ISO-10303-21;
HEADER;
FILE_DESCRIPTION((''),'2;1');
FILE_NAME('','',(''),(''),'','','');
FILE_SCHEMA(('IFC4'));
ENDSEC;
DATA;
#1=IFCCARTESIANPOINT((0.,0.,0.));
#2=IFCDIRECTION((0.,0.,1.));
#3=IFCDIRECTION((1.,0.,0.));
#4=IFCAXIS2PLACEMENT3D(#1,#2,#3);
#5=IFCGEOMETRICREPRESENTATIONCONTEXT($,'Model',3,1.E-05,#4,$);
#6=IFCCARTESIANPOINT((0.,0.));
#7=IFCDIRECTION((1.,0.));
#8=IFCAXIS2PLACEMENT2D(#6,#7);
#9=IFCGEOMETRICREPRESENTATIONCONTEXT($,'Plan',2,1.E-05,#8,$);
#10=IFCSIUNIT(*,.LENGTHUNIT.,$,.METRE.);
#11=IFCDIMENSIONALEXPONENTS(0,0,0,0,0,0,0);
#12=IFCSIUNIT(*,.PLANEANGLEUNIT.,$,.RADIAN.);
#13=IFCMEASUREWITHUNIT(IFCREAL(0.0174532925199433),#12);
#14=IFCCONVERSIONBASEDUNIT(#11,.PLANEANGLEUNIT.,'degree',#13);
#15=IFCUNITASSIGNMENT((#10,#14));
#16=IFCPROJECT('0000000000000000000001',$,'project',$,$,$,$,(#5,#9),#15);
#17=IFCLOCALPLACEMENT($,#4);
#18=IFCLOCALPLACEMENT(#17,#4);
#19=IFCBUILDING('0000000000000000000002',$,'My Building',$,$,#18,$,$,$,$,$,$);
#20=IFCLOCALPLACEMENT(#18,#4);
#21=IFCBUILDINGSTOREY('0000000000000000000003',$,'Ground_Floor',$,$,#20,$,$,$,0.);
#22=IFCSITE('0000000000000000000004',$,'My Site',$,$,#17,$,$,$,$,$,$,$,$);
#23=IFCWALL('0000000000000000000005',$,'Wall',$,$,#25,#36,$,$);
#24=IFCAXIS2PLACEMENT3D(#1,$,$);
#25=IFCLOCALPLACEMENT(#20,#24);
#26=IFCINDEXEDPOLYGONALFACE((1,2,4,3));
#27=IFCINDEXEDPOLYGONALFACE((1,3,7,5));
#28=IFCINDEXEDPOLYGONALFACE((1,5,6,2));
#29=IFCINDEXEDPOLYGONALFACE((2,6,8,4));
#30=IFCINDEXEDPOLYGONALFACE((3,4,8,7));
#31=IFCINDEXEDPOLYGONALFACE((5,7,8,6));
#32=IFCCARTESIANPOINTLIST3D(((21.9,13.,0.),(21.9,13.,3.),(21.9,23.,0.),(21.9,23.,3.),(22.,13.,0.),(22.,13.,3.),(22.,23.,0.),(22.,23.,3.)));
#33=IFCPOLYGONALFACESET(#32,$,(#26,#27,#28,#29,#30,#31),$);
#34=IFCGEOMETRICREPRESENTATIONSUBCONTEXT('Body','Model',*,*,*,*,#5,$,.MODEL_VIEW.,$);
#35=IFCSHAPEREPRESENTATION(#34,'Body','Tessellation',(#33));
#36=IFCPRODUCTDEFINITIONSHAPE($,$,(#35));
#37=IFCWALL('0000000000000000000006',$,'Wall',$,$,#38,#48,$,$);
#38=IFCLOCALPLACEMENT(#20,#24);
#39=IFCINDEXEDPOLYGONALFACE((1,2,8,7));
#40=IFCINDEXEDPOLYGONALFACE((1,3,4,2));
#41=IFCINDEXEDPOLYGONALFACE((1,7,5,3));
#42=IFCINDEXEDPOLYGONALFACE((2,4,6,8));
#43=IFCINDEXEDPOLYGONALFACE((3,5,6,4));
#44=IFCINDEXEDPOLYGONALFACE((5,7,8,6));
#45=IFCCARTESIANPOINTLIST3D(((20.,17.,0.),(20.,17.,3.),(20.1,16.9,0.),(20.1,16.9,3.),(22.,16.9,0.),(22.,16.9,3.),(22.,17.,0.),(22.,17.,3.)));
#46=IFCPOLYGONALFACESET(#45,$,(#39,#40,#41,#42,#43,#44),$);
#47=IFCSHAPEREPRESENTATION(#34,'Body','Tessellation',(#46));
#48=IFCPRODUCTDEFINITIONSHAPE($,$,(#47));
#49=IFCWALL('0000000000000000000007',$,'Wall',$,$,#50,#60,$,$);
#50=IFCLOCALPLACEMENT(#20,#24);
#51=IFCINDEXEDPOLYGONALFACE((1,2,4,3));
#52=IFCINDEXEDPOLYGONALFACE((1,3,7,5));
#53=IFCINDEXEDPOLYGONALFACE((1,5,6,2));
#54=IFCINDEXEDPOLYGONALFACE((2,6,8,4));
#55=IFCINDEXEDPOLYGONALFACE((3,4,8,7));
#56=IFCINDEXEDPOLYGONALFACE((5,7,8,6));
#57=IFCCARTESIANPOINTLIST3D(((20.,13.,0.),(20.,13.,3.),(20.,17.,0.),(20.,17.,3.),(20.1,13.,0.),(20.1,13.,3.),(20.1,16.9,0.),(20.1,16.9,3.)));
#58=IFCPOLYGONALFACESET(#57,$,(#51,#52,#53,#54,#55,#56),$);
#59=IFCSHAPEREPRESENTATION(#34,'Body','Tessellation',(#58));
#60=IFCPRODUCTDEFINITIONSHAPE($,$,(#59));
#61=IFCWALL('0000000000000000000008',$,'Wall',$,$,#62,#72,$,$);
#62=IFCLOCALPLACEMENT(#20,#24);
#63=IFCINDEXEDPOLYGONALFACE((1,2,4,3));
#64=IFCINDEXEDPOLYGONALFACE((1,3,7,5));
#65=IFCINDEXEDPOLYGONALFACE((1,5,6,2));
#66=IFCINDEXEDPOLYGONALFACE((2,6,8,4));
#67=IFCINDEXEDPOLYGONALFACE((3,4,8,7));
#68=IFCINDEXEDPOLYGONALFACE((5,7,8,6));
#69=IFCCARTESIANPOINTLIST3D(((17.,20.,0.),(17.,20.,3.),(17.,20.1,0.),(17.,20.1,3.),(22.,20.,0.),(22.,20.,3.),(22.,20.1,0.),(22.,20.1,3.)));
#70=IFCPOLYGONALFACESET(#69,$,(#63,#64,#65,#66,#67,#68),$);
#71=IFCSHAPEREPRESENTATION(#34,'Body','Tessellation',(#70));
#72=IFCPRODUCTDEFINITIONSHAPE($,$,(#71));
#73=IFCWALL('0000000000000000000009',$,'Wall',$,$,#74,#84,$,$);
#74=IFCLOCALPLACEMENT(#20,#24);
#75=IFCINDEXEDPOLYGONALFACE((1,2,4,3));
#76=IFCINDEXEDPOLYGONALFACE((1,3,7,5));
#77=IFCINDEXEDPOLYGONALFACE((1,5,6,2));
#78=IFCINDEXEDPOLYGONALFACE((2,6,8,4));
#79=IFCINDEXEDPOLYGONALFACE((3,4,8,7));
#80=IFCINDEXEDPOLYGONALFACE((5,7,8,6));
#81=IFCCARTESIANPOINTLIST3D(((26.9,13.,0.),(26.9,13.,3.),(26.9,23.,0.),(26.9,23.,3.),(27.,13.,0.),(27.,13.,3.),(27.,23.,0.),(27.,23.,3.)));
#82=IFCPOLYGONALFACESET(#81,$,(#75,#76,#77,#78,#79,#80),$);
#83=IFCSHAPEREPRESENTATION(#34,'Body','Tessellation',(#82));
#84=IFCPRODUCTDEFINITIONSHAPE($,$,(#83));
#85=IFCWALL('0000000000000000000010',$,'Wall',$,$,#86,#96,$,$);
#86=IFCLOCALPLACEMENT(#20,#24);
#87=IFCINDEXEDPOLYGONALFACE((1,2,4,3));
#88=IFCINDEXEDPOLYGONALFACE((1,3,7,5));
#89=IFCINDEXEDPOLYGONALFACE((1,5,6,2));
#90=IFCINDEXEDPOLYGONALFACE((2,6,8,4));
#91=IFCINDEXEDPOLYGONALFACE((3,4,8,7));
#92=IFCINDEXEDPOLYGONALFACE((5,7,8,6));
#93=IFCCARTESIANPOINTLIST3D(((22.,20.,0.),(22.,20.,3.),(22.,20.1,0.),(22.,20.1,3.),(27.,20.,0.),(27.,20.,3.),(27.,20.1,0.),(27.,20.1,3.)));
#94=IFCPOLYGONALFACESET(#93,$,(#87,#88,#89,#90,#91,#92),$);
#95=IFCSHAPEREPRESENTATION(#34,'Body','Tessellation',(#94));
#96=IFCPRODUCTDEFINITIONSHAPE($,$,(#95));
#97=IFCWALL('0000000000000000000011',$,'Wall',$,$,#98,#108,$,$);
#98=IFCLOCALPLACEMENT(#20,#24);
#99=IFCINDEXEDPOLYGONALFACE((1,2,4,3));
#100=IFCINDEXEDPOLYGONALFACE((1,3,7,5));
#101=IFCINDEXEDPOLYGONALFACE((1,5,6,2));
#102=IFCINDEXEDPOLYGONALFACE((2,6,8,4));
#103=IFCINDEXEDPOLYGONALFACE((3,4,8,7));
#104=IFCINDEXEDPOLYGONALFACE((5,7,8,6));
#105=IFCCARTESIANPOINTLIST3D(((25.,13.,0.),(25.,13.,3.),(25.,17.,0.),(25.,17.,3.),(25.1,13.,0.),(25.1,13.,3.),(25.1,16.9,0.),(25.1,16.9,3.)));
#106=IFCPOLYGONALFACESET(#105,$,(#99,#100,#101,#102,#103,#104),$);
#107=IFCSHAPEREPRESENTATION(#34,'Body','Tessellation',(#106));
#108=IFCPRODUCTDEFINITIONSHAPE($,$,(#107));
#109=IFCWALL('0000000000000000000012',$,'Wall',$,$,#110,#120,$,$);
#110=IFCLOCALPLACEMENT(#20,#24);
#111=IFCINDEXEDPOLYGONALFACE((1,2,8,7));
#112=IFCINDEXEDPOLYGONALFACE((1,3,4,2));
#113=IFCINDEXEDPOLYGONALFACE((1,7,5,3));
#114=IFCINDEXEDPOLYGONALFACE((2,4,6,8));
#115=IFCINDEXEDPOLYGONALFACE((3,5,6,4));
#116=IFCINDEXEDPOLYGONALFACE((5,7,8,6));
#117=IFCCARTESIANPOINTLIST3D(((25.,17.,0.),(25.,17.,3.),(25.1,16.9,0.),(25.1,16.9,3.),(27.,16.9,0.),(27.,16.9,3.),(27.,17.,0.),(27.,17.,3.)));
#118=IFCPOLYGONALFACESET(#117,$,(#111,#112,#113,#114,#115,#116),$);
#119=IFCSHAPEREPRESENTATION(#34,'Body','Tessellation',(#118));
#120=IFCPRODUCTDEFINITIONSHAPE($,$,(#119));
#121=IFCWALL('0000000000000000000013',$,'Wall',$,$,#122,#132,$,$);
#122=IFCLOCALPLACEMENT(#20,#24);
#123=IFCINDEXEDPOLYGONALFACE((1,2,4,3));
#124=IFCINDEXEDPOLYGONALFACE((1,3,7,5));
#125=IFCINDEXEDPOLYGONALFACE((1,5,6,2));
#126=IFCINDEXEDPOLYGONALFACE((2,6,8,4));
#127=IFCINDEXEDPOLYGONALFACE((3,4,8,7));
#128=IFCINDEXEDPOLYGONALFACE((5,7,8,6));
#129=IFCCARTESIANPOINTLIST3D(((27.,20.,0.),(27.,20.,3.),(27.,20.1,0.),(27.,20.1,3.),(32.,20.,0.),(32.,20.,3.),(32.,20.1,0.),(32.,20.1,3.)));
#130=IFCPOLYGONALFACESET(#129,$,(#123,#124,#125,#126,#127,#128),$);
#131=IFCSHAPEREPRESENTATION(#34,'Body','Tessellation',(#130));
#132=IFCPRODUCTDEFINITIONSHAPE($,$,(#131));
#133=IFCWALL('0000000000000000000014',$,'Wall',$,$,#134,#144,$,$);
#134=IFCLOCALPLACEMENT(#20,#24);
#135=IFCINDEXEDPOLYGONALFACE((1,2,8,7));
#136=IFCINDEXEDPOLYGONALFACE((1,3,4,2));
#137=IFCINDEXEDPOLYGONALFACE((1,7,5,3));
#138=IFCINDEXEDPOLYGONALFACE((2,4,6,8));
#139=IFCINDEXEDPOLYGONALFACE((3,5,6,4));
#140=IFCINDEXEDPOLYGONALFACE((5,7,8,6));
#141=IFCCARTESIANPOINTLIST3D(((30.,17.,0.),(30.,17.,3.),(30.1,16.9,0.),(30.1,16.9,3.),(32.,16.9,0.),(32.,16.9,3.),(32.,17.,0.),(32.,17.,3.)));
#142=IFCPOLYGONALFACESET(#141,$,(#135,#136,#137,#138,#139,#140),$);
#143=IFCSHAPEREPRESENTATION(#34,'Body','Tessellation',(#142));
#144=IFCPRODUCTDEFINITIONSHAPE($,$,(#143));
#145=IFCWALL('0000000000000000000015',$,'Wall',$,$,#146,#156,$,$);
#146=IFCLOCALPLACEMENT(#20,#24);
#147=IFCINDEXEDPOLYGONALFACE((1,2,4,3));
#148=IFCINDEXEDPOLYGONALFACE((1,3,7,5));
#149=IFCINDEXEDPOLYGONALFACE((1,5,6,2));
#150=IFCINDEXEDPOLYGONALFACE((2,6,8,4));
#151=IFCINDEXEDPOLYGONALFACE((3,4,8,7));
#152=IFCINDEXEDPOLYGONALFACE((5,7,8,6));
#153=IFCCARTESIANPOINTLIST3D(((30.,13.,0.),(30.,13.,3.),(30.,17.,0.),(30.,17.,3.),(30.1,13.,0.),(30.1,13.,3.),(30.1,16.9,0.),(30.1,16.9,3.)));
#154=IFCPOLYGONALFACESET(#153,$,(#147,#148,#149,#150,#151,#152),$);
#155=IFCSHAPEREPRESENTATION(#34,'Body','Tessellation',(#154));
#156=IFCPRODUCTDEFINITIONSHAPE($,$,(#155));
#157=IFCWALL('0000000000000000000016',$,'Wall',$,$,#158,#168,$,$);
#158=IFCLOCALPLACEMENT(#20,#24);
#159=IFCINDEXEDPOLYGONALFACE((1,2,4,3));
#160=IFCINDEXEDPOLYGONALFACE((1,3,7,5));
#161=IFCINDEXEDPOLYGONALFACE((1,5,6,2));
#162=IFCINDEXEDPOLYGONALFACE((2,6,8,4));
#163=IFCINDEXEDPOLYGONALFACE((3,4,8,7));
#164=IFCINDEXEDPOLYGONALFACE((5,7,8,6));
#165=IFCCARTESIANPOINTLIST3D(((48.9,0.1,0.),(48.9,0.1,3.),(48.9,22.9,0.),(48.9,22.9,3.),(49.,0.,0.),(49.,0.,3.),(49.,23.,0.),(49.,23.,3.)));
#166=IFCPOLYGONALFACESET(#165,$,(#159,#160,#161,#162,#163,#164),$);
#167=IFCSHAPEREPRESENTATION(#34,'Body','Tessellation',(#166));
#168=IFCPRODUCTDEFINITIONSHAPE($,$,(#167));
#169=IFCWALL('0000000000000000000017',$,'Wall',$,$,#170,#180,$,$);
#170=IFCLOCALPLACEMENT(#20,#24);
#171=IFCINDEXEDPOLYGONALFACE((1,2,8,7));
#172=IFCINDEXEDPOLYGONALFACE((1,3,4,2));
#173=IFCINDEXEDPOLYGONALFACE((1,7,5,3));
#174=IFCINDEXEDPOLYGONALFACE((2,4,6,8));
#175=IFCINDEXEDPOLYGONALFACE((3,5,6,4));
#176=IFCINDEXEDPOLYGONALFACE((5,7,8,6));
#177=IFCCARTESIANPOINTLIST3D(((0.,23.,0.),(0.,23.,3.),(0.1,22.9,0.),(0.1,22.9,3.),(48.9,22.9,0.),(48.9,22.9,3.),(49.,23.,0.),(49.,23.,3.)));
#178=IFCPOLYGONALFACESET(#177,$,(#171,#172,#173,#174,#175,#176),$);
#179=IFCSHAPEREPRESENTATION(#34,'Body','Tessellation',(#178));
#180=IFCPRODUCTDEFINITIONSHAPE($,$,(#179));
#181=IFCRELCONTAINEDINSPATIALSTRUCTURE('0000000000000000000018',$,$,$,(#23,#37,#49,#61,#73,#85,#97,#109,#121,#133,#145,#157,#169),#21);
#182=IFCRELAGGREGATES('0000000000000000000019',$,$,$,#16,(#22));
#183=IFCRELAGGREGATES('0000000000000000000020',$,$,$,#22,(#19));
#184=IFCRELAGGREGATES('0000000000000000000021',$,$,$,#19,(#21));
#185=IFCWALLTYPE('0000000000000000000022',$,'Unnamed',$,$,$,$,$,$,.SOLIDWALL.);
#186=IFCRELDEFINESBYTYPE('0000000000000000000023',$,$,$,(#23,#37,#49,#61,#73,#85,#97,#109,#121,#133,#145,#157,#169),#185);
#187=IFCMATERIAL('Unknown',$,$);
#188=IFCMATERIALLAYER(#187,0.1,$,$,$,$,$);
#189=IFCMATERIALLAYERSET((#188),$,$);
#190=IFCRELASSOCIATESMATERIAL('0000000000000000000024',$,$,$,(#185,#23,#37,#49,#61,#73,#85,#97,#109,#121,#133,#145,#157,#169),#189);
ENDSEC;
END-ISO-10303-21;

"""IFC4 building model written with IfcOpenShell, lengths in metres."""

from ifc_helpers import new_model, entity, si_unit, converted_unit, frame, origin_with_axes, origin_2d_with_axis, place, context, subcontext, project, spatial, line, indexed_curve, outline, extrude, material, layer, layer_set, layer_usage, type_object, element, save


model = new_model("IFC4")

# Units and contexts
model_context = context("Model", 3, precision=1e-05, world=origin_with_axes())
plan_context = context("Plan", 2, precision=1e-05, world=origin_2d_with_axis())
body_context = subcontext(model_context, "Body", "Model", "MODEL_VIEW")
ifc_project = project(units=[si_unit("LENGTHUNIT", "METRE"), converted_unit("PLANEANGLEUNIT", "degree", entity("IfcReal", 0.0174532925199433), si_unit("PLANEANGLEUNIT", "RADIAN"), dimensions=[0, 0, 0, 0, 0, 0, 0])], contexts=[model_context, plan_context])

# Site, building, storey
site_placement = place(None, origin_with_axes())
site = spatial("IfcSite", under=ifc_project, at=site_placement, Name="My Site")
building_placement = place(site_placement, origin_with_axes())
building = spatial("IfcBuilding", under=site, at=building_placement, Name="My Building")
storey_placement = place(building_placement, origin_with_axes())
storey = spatial("IfcBuildingStorey", under=building, at=storey_placement, Name="Ground_Floor", Elevation=0.0)

# Walls
ifc_material = material(Name="Unknown")
ifc_layer = layer(ifc_material, 0.1)
ifc_layer_set = layer_set([ifc_layer])
wall_type = type_object("IfcWallType", Name="Unnamed", PredefinedType="SOLIDWALL", material=ifc_layer_set)
ifc_layer_usage_1 = layer_usage(ifc_layer_set, "AXIS2", "POSITIVE", 0.0)
wall_1_placement = place(storey_placement, frame((22.0, 13.0, 0.0), z_axis=(0.0, 0.0, 1.0), x_axis=(0.0, 1.0, 0.0)))
element("IfcWall", 1, at=wall_1_placement, inside=storey, type_object=wall_type, material=ifc_layer_usage_1, Name="Wall", context=body_context, shape_type="SweptSolid", body=[
    extrude(outline(indexed_curve([(0.0, 0.0), (0.0, 0.1), (10.0, 0.1), (10.0, 0.0)], segments=[line(1, 2, 3, 4, 1)])), origin_with_axes(), (0.0, 0.0, 1.0), 3.0),
])
ifc_layer_usage_2 = layer_usage(ifc_layer_set, "AXIS2", "POSITIVE", 0.0)
wall_2_placement = place(storey_placement, frame((22.0, 17.0, 0.0), z_axis=(0.0, 0.0, 1.0), x_axis=(-1.0, 0.0, 0.0)))
element("IfcWall", 2, at=wall_2_placement, inside=storey, type_object=wall_type, material=ifc_layer_usage_2, Name="Wall", context=body_context, shape_type="SweptSolid", body=[
    extrude(outline(indexed_curve([(0.0, 0.0), (0.0, 0.1), (1.9, 0.1), (2.0, 0.0)], segments=[line(1, 2, 3, 4, 1)])), origin_with_axes(), (0.0, 0.0, 1.0), 3.0),
])
ifc_layer_usage_3 = layer_usage(ifc_layer_set, "AXIS2", "POSITIVE", 0.0)
wall_3_placement = place(storey_placement, frame((20.0, 17.0, 0.0), z_axis=(0.0, 0.0, 1.0), x_axis=(0.0, -1.0, 0.0)))
element("IfcWall", 3, at=wall_3_placement, inside=storey, type_object=wall_type, material=ifc_layer_usage_3, Name="Wall", context=body_context, shape_type="SweptSolid", body=[
    extrude(outline(indexed_curve([(0.0, 0.0), (0.1, 0.1), (4.0, 0.1), (4.0, 0.0)], segments=[line(1, 2, 3, 4, 1)])), origin_with_axes(), (0.0, 0.0, 1.0), 3.0),
])
ifc_layer_usage_4 = layer_usage(ifc_layer_set, "AXIS2", "POSITIVE", 0.0)
wall_4_placement = place(storey_placement, frame((17.0, 20.0, 0.0), z_axis=(0.0, 0.0, 1.0), x_axis=(1.0, 0.0, 0.0)))
element("IfcWall", 4, at=wall_4_placement, inside=storey, type_object=wall_type, material=ifc_layer_usage_4, Name="Wall", context=body_context, shape_type="SweptSolid", body=[
    extrude(outline(indexed_curve([(0.0, 0.0), (0.0, 0.1), (5.0, 0.1), (5.0, 0.0)], segments=[line(1, 2, 3, 4, 1)])), origin_with_axes(), (0.0, 0.0, 1.0), 3.0),
])
ifc_layer_usage_5 = layer_usage(ifc_layer_set, "AXIS2", "POSITIVE", 0.0)
wall_5_placement = place(storey_placement, frame((27.0, 13.0, 0.0), z_axis=(0.0, 0.0, 1.0), x_axis=(0.0, 1.0, 0.0)))
element("IfcWall", 5, at=wall_5_placement, inside=storey, type_object=wall_type, material=ifc_layer_usage_5, Name="Wall", context=body_context, shape_type="SweptSolid", body=[
    extrude(outline(indexed_curve([(0.0, 0.0), (0.0, 0.1), (10.0, 0.1), (10.0, 0.0)], segments=[line(1, 2, 3, 4, 1)])), origin_with_axes(), (0.0, 0.0, 1.0), 3.0),
])
ifc_layer_usage_6 = layer_usage(ifc_layer_set, "AXIS2", "POSITIVE", 0.0)
wall_6_placement = place(storey_placement, frame((22.0, 20.0, 0.0), z_axis=(0.0, 0.0, 1.0), x_axis=(1.0, 0.0, 0.0)))
element("IfcWall", 6, at=wall_6_placement, inside=storey, type_object=wall_type, material=ifc_layer_usage_6, Name="Wall", context=body_context, shape_type="SweptSolid", body=[
    extrude(outline(indexed_curve([(0.0, 0.0), (0.0, 0.1), (5.0, 0.1), (5.0, 0.0)], segments=[line(1, 2, 3, 4, 1)])), origin_with_axes(), (0.0, 0.0, 1.0), 3.0),
])
ifc_layer_usage_7 = layer_usage(ifc_layer_set, "AXIS2", "POSITIVE", 0.0)
wall_7_placement = place(storey_placement, frame((25.0, 17.0, 0.0), z_axis=(0.0, 0.0, 1.0), x_axis=(0.0, -1.0, 0.0)))
element("IfcWall", 7, at=wall_7_placement, inside=storey, type_object=wall_type, material=ifc_layer_usage_7, Name="Wall", context=body_context, shape_type="SweptSolid", body=[
    extrude(outline(indexed_curve([(0.0, 0.0), (0.1, 0.1), (4.0, 0.1), (4.0, 0.0)], segments=[line(1, 2, 3, 4, 1)])), origin_with_axes(), (0.0, 0.0, 1.0), 3.0),
])
ifc_layer_usage_8 = layer_usage(ifc_layer_set, "AXIS2", "POSITIVE", 0.0)
wall_8_placement = place(storey_placement, frame((27.0, 17.0, 0.0), z_axis=(0.0, 0.0, 1.0), x_axis=(-1.0, 0.0, 0.0)))
element("IfcWall", 8, at=wall_8_placement, inside=storey, type_object=wall_type, material=ifc_layer_usage_8, Name="Wall", context=body_context, shape_type="SweptSolid", body=[
    extrude(outline(indexed_curve([(0.0, 0.0), (0.0, 0.1), (1.9, 0.1), (2.0, 0.0)], segments=[line(1, 2, 3, 4, 1)])), origin_with_axes(), (0.0, 0.0, 1.0), 3.0),
])
ifc_layer_usage_9 = layer_usage(ifc_layer_set, "AXIS2", "POSITIVE", 0.0)
wall_9_placement = place(storey_placement, frame((27.0, 20.0, 0.0), z_axis=(0.0, 0.0, 1.0), x_axis=(1.0, 0.0, 0.0)))
element("IfcWall", 9, at=wall_9_placement, inside=storey, type_object=wall_type, material=ifc_layer_usage_9, Name="Wall", context=body_context, shape_type="SweptSolid", body=[
    extrude(outline(indexed_curve([(0.0, 0.0), (0.0, 0.1), (5.0, 0.1), (5.0, 0.0)], segments=[line(1, 2, 3, 4, 1)])), origin_with_axes(), (0.0, 0.0, 1.0), 3.0),
])
ifc_layer_usage_10 = layer_usage(ifc_layer_set, "AXIS2", "POSITIVE", 0.0)
wall_10_placement = place(storey_placement, frame((32.0, 17.0, 0.0), z_axis=(0.0, 0.0, 1.0), x_axis=(-1.0, 0.0, 0.0)))
element("IfcWall", 10, at=wall_10_placement, inside=storey, type_object=wall_type, material=ifc_layer_usage_10, Name="Wall", context=body_context, shape_type="SweptSolid", body=[
    extrude(outline(indexed_curve([(0.0, 0.0), (0.0, 0.1), (1.9, 0.1), (2.0, 0.0)], segments=[line(1, 2, 3, 4, 1)])), origin_with_axes(), (0.0, 0.0, 1.0), 3.0),
])
ifc_layer_usage_11 = layer_usage(ifc_layer_set, "AXIS2", "POSITIVE", 0.0)
wall_11_placement = place(storey_placement, frame((30.0, 17.0, 0.0), z_axis=(0.0, 0.0, 1.0), x_axis=(0.0, -1.0, 0.0)))
element("IfcWall", 11, at=wall_11_placement, inside=storey, type_object=wall_type, material=ifc_layer_usage_11, Name="Wall", context=body_context, shape_type="SweptSolid", body=[
    extrude(outline(indexed_curve([(0.0, 0.0), (0.1, 0.1), (4.0, 0.1), (4.0, 0.0)], segments=[line(1, 2, 3, 4, 1)])), origin_with_axes(), (0.0, 0.0, 1.0), 3.0),
])
ifc_layer_usage_12 = layer_usage(ifc_layer_set, "AXIS2", "POSITIVE", 0.0)
wall_12_placement = place(storey_placement, frame((49.0, 0.0, 0.0), z_axis=(0.0, 0.0, 1.0), x_axis=(0.0, 1.0, 0.0)))
element("IfcWall", 12, at=wall_12_placement, inside=storey, type_object=wall_type, material=ifc_layer_usage_12, Name="Wall", context=body_context, shape_type="SweptSolid", body=[
    extrude(outline(indexed_curve([(0.0, 0.0), (0.1, 0.1), (22.9, 0.1), (23.0, 0.0)], segments=[line(1, 2, 3, 4, 1)])), origin_with_axes(), (0.0, 0.0, 1.0), 3.0),
])
ifc_layer_usage_13 = layer_usage(ifc_layer_set, "AXIS2", "POSITIVE", 0.0)
wall_13_placement = place(storey_placement, frame((49.0, 23.0, 0.0), z_axis=(0.0, 0.0, 1.0), x_axis=(-1.0, 0.0, 0.0)))
element("IfcWall", 13, at=wall_13_placement, inside=storey, type_object=wall_type, material=ifc_layer_usage_13, Name="Wall", context=body_context, shape_type="SweptSolid", body=[
    extrude(outline(indexed_curve([(0.0, 0.0), (0.1, 0.1), (48.9, 0.1), (49.0, 0.0)], segments=[line(1, 2, 3, 4, 1)])), origin_with_axes(), (0.0, 0.0, 1.0), 3.0),
])

save(model, "model.ifc")
